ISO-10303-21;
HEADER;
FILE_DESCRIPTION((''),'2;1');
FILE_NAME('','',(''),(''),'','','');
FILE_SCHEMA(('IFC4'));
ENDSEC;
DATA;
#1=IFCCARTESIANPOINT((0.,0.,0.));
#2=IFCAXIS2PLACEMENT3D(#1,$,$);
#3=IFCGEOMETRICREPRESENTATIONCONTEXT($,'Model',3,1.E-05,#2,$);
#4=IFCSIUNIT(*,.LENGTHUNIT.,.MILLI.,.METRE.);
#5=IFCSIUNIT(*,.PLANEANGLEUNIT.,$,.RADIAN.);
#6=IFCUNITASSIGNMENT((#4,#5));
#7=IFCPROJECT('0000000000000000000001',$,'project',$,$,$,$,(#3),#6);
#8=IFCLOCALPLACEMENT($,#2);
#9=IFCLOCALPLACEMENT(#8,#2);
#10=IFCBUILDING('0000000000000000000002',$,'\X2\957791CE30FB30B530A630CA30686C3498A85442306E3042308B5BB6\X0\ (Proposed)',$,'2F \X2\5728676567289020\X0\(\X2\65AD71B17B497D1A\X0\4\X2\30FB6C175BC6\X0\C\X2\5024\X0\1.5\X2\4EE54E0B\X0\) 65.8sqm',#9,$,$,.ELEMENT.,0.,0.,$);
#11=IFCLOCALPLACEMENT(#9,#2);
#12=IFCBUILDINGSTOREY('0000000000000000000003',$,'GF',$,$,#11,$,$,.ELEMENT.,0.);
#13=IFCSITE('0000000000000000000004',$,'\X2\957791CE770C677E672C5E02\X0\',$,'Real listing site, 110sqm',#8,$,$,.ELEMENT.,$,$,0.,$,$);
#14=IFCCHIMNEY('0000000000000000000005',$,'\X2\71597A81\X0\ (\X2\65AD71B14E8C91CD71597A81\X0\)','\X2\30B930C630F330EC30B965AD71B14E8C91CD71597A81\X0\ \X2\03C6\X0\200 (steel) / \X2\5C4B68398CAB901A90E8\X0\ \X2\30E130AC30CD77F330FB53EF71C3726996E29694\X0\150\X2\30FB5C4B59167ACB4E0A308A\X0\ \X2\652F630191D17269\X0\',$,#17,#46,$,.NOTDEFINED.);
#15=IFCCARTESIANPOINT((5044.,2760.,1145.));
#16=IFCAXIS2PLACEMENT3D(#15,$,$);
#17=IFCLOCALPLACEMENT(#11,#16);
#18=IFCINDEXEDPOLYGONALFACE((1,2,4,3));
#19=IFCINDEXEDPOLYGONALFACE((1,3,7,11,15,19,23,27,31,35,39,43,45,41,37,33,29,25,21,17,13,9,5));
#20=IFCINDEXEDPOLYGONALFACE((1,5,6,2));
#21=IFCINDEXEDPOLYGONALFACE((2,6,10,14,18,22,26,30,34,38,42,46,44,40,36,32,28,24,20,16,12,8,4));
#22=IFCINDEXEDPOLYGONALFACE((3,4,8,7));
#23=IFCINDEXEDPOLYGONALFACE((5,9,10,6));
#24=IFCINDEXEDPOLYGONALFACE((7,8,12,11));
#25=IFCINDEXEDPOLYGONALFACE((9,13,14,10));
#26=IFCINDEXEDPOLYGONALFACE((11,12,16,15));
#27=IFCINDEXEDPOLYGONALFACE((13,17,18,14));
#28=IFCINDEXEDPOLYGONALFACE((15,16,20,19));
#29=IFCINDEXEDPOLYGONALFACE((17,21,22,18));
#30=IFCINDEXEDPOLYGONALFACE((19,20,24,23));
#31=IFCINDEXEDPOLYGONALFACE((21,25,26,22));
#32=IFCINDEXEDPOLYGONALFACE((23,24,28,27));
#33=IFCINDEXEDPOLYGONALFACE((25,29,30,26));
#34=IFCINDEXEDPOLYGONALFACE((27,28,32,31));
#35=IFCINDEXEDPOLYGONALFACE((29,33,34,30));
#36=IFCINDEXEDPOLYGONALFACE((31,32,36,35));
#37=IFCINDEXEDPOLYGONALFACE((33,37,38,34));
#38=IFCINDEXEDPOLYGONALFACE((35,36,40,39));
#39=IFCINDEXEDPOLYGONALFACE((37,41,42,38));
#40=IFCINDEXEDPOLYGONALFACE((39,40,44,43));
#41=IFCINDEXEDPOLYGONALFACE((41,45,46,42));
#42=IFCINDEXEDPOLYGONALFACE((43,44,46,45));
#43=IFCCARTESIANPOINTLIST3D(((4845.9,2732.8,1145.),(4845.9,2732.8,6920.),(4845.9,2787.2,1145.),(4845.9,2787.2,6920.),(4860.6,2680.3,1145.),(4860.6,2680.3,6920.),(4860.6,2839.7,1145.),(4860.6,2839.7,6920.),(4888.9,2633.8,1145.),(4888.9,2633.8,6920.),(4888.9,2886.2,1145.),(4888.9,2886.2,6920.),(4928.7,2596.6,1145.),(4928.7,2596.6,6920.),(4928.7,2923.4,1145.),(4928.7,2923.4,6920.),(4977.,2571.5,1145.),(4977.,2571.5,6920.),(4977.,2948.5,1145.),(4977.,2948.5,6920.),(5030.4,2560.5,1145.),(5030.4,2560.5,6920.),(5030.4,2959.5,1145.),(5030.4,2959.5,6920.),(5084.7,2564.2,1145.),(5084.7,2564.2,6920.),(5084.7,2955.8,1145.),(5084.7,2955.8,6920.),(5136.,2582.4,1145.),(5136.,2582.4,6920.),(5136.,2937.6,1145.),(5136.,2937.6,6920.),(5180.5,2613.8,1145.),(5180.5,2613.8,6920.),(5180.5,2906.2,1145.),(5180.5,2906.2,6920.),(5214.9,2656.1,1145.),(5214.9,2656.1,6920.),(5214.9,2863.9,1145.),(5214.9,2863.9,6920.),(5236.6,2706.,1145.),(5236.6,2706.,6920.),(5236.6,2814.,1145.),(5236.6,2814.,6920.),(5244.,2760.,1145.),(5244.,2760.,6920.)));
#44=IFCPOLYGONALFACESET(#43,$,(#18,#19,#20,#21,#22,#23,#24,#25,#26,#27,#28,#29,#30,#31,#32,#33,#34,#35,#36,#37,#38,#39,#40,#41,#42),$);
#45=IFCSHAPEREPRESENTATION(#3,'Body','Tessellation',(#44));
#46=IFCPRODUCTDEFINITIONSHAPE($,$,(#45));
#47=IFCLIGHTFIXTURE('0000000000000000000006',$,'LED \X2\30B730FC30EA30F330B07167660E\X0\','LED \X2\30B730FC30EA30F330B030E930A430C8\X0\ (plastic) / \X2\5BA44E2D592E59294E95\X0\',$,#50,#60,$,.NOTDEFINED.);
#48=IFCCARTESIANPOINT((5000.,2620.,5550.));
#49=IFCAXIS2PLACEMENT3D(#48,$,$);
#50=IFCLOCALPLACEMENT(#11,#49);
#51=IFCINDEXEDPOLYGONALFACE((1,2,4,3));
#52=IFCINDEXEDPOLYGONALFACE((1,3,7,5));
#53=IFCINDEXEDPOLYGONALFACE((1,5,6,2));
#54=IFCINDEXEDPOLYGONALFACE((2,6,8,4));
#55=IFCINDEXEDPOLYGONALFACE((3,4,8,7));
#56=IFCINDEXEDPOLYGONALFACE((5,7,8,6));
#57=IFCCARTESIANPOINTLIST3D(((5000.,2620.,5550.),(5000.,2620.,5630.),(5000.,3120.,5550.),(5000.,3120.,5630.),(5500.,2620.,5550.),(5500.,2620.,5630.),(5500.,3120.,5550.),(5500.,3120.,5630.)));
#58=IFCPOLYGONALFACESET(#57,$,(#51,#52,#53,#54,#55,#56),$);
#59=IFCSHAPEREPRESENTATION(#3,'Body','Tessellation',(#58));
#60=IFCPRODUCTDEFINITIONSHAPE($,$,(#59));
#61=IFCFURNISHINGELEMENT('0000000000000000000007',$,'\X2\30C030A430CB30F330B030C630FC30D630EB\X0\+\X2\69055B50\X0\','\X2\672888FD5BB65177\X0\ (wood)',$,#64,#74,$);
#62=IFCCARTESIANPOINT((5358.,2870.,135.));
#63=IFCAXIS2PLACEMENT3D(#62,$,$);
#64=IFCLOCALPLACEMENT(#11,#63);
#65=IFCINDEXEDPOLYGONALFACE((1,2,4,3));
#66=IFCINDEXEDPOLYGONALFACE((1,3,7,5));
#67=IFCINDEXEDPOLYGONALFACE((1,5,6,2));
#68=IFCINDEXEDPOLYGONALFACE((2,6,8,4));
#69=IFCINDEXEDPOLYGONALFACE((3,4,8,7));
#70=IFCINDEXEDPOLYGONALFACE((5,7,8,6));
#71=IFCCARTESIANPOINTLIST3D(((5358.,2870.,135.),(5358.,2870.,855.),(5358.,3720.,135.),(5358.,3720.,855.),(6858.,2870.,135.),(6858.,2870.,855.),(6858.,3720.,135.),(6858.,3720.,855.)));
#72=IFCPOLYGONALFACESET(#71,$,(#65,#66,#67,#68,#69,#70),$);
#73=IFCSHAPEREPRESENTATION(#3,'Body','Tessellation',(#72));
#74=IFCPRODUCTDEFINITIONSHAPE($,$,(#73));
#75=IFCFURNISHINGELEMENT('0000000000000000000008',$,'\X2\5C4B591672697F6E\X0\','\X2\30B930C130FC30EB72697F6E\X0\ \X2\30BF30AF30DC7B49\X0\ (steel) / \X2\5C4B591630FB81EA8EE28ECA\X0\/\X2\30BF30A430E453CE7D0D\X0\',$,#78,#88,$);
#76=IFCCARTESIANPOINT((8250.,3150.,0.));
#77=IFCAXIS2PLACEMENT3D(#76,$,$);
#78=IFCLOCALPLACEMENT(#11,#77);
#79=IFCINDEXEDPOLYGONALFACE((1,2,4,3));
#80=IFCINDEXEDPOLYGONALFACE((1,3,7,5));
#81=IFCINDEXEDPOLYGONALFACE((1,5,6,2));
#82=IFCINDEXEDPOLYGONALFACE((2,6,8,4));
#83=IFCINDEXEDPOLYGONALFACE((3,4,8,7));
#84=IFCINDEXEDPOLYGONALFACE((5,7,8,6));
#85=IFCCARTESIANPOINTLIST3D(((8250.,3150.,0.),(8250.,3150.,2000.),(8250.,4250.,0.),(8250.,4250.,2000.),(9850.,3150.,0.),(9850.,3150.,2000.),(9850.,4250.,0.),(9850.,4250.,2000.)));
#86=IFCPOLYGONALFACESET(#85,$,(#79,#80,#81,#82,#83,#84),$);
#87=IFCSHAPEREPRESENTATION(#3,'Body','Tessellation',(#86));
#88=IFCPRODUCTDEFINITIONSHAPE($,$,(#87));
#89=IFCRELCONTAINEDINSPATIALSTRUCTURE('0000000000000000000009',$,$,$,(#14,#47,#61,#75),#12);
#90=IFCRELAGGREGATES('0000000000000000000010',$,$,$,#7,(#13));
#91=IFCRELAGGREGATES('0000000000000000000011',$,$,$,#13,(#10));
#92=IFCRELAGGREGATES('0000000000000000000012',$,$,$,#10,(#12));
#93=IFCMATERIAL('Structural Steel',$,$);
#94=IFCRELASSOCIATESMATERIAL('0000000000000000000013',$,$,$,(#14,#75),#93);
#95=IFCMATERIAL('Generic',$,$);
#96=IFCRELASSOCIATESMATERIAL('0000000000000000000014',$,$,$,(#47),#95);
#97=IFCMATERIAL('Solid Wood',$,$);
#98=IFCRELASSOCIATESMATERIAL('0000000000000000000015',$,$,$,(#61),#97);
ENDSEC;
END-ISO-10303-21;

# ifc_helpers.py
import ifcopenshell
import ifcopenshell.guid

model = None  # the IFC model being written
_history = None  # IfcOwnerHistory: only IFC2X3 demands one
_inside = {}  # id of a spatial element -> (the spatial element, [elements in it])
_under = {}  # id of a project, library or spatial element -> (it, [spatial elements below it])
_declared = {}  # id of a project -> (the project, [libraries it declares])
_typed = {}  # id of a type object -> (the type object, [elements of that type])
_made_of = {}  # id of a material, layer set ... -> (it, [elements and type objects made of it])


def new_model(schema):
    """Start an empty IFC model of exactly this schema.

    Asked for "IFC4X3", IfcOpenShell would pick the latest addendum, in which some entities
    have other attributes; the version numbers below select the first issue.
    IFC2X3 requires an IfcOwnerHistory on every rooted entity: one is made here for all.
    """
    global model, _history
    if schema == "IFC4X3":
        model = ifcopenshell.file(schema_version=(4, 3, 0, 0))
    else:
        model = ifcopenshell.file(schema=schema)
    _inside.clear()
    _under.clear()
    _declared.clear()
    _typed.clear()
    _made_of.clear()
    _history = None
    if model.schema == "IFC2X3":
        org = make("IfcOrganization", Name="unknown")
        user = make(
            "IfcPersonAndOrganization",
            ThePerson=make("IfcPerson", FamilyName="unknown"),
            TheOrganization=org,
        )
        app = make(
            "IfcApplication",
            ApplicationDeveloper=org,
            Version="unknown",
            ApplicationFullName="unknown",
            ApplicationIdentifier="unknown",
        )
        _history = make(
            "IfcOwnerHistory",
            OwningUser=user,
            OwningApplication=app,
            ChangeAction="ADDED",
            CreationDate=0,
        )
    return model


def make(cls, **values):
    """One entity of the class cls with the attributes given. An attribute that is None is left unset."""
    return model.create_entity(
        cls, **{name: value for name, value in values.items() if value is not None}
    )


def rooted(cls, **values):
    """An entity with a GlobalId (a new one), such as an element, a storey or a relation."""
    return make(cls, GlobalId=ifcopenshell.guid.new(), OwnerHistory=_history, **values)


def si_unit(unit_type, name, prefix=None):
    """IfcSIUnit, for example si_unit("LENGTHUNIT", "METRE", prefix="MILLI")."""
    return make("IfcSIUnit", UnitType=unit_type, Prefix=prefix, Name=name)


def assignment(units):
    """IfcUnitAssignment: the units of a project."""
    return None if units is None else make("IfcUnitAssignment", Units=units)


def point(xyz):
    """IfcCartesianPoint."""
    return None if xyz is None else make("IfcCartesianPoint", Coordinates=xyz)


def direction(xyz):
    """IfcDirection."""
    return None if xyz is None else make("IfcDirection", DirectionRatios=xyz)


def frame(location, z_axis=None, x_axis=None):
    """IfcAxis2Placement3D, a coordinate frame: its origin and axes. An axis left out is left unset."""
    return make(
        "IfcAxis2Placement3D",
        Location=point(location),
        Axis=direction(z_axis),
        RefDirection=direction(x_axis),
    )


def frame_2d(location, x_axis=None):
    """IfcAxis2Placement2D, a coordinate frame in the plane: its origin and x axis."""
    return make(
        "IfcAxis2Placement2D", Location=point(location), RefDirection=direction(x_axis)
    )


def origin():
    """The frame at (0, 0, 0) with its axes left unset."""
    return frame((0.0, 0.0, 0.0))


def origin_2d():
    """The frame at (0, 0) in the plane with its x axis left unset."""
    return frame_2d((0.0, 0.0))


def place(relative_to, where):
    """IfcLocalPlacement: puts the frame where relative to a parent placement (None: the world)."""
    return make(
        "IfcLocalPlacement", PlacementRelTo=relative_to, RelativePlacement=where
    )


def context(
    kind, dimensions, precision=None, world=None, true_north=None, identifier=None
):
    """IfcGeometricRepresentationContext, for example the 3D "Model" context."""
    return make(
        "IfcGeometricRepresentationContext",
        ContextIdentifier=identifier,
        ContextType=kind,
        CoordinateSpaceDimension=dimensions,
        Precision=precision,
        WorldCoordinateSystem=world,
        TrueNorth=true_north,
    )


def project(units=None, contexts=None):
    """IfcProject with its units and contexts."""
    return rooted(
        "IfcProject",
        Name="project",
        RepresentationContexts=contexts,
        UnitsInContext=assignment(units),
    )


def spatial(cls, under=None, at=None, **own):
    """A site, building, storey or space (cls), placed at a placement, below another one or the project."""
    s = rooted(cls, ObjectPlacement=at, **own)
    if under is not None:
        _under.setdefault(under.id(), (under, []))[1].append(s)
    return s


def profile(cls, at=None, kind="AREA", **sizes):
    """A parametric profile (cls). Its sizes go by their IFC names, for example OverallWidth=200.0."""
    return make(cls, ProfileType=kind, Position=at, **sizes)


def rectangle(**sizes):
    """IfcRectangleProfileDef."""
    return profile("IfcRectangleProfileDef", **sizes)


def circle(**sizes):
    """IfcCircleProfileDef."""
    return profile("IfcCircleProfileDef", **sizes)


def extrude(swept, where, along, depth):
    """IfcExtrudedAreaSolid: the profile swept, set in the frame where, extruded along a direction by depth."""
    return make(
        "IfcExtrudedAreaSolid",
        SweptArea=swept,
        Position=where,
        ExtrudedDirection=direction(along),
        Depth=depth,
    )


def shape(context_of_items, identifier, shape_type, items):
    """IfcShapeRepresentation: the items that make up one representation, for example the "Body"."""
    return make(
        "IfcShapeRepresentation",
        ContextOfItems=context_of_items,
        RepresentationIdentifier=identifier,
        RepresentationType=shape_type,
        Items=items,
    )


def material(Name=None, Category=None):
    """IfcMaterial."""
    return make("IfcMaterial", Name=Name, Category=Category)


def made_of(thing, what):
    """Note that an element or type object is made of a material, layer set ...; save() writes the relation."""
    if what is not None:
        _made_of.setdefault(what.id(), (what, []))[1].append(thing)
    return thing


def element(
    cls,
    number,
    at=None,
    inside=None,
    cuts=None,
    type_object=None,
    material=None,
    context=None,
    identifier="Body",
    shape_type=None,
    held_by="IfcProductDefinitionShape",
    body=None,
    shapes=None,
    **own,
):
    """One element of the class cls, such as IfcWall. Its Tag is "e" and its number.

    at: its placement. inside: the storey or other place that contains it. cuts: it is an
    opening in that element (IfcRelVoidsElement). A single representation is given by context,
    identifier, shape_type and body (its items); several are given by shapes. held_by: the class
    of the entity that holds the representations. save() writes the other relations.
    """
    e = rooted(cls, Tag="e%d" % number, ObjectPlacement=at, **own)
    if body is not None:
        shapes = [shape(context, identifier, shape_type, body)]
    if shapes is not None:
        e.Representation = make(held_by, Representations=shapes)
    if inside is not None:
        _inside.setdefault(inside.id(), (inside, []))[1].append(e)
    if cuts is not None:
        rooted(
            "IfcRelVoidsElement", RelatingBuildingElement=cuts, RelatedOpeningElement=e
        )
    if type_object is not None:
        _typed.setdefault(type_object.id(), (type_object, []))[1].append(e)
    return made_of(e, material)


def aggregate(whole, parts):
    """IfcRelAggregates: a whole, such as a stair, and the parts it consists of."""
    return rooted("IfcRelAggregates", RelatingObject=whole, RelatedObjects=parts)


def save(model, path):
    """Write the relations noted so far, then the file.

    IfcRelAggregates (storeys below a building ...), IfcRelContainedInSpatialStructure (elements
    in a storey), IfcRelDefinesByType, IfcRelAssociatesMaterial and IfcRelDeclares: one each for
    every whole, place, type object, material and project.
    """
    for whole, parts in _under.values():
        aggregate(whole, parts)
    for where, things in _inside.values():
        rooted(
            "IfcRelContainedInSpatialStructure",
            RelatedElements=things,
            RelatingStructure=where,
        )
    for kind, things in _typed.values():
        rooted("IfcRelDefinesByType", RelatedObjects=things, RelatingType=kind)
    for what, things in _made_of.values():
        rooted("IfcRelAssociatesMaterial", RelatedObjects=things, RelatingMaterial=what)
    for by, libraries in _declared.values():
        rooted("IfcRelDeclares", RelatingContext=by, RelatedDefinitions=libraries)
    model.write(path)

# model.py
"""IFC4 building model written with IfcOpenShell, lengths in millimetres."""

from ifc_helpers import new_model, si_unit, frame, frame_2d, origin, origin_2d, place, context, project, spatial, rectangle, circle, extrude, material, element, save


model = new_model("IFC4")

# Units and contexts
model_context = context("Model", 3, precision=1e-05, world=origin())
ifc_project = project(units=[si_unit("LENGTHUNIT", "METRE", prefix="MILLI"), si_unit("PLANEANGLEUNIT", "RADIAN")], contexts=[model_context])

# Site, building, storey
site_placement = place(None, origin())
site = spatial("IfcSite", under=ifc_project, at=site_placement, Name="長野県松本市", ObjectType="Real listing site, 110sqm", CompositionType="ELEMENT", RefElevation=0.0)
building_placement = place(site_placement, origin())
building = spatial("IfcBuilding", under=site, at=building_placement, Name="長野・サウナと水風呂のある家 (Proposed)", ObjectType="2F 在来木造(断熱等級4・気密C値1.5以下) 65.8sqm", CompositionType="ELEMENT", ElevationOfRefHeight=0.0, ElevationOfTerrain=0.0)
storey_placement = place(building_placement, origin())
storey = spatial("IfcBuildingStorey", under=building, at=storey_placement, Name="GF", CompositionType="ELEMENT", Elevation=0.0)

# Shared definitions
ifc_material_1 = material(Name="Solid Wood")

# Shared definitions
ifc_material_2 = material(Name="Structural Steel")

# Chimney
chimney_placement = place(storey_placement, frame((5044.0, 2760.0, 1145.0)))
element("IfcChimney", 1, at=chimney_placement, inside=storey, material=ifc_material_2, Name="煙突 (断熱二重煙突)", Description="ステンレス断熱二重煙突 φ200 (steel) / 屋根貫通部 メガネ石・可燃物離隔150・屋外立上り 支持金物", PredefinedType="NOTDEFINED", context=model_context, shape_type="SweptSolid", body=[
    extrude(circle(Radius=200.0, at=origin_2d()), frame((5044.0, 2760.0, 1145.0)), (0.0, 0.0, 1.0), 5775.0),
])

# Light fixture
ifc_material_3 = material(Name="Generic")
light_fixture_placement = place(storey_placement, frame((5000.0, 2620.0, 5550.0)))
element("IfcLightFixture", 2, at=light_fixture_placement, inside=storey, material=ifc_material_3, Name="LED シーリング照明", Description="LED シーリングライト (plastic) / 室中央天井", PredefinedType="NOTDEFINED", context=model_context, shape_type="SweptSolid", body=[
    extrude(rectangle(XDim=500.0, YDim=500.0, at=frame_2d((250.0, 250.0))), frame((5000.0, 2620.0, 5550.0)), (0.0, 0.0, 1.0), 80.0),
])

# Furnishing elements
furnishing_1_placement = place(storey_placement, frame((5358.0, 2870.0, 135.0)))
element("IfcFurnishingElement", 3, at=furnishing_1_placement, inside=storey, material=ifc_material_1, Name="ダイニングテーブル+椅子", Description="木製家具 (wood)", context=model_context, shape_type="SweptSolid", body=[
    extrude(rectangle(XDim=1500.0, YDim=850.0, at=frame_2d((750.0, 425.0))), frame((5358.0, 2870.0, 135.0)), (0.0, 0.0, 1.0), 720.0),
])
furnishing_2_placement = place(storey_placement, frame((8250.0, 3150.0, 0.0)))
element("IfcFurnishingElement", 4, at=furnishing_2_placement, inside=storey, material=ifc_material_2, Name="屋外物置", Description="スチール物置 タクボ等 (steel) / 屋外・自転車/タイヤ収納", context=model_context, shape_type="SweptSolid", body=[
    extrude(rectangle(XDim=1600.0, YDim=1100.0, at=frame_2d((800.0, 550.0))), frame((8250.0, 3150.0, 0.0)), (0.0, 0.0, 1.0), 2000.0),
])

save(model, "model.ifc")
